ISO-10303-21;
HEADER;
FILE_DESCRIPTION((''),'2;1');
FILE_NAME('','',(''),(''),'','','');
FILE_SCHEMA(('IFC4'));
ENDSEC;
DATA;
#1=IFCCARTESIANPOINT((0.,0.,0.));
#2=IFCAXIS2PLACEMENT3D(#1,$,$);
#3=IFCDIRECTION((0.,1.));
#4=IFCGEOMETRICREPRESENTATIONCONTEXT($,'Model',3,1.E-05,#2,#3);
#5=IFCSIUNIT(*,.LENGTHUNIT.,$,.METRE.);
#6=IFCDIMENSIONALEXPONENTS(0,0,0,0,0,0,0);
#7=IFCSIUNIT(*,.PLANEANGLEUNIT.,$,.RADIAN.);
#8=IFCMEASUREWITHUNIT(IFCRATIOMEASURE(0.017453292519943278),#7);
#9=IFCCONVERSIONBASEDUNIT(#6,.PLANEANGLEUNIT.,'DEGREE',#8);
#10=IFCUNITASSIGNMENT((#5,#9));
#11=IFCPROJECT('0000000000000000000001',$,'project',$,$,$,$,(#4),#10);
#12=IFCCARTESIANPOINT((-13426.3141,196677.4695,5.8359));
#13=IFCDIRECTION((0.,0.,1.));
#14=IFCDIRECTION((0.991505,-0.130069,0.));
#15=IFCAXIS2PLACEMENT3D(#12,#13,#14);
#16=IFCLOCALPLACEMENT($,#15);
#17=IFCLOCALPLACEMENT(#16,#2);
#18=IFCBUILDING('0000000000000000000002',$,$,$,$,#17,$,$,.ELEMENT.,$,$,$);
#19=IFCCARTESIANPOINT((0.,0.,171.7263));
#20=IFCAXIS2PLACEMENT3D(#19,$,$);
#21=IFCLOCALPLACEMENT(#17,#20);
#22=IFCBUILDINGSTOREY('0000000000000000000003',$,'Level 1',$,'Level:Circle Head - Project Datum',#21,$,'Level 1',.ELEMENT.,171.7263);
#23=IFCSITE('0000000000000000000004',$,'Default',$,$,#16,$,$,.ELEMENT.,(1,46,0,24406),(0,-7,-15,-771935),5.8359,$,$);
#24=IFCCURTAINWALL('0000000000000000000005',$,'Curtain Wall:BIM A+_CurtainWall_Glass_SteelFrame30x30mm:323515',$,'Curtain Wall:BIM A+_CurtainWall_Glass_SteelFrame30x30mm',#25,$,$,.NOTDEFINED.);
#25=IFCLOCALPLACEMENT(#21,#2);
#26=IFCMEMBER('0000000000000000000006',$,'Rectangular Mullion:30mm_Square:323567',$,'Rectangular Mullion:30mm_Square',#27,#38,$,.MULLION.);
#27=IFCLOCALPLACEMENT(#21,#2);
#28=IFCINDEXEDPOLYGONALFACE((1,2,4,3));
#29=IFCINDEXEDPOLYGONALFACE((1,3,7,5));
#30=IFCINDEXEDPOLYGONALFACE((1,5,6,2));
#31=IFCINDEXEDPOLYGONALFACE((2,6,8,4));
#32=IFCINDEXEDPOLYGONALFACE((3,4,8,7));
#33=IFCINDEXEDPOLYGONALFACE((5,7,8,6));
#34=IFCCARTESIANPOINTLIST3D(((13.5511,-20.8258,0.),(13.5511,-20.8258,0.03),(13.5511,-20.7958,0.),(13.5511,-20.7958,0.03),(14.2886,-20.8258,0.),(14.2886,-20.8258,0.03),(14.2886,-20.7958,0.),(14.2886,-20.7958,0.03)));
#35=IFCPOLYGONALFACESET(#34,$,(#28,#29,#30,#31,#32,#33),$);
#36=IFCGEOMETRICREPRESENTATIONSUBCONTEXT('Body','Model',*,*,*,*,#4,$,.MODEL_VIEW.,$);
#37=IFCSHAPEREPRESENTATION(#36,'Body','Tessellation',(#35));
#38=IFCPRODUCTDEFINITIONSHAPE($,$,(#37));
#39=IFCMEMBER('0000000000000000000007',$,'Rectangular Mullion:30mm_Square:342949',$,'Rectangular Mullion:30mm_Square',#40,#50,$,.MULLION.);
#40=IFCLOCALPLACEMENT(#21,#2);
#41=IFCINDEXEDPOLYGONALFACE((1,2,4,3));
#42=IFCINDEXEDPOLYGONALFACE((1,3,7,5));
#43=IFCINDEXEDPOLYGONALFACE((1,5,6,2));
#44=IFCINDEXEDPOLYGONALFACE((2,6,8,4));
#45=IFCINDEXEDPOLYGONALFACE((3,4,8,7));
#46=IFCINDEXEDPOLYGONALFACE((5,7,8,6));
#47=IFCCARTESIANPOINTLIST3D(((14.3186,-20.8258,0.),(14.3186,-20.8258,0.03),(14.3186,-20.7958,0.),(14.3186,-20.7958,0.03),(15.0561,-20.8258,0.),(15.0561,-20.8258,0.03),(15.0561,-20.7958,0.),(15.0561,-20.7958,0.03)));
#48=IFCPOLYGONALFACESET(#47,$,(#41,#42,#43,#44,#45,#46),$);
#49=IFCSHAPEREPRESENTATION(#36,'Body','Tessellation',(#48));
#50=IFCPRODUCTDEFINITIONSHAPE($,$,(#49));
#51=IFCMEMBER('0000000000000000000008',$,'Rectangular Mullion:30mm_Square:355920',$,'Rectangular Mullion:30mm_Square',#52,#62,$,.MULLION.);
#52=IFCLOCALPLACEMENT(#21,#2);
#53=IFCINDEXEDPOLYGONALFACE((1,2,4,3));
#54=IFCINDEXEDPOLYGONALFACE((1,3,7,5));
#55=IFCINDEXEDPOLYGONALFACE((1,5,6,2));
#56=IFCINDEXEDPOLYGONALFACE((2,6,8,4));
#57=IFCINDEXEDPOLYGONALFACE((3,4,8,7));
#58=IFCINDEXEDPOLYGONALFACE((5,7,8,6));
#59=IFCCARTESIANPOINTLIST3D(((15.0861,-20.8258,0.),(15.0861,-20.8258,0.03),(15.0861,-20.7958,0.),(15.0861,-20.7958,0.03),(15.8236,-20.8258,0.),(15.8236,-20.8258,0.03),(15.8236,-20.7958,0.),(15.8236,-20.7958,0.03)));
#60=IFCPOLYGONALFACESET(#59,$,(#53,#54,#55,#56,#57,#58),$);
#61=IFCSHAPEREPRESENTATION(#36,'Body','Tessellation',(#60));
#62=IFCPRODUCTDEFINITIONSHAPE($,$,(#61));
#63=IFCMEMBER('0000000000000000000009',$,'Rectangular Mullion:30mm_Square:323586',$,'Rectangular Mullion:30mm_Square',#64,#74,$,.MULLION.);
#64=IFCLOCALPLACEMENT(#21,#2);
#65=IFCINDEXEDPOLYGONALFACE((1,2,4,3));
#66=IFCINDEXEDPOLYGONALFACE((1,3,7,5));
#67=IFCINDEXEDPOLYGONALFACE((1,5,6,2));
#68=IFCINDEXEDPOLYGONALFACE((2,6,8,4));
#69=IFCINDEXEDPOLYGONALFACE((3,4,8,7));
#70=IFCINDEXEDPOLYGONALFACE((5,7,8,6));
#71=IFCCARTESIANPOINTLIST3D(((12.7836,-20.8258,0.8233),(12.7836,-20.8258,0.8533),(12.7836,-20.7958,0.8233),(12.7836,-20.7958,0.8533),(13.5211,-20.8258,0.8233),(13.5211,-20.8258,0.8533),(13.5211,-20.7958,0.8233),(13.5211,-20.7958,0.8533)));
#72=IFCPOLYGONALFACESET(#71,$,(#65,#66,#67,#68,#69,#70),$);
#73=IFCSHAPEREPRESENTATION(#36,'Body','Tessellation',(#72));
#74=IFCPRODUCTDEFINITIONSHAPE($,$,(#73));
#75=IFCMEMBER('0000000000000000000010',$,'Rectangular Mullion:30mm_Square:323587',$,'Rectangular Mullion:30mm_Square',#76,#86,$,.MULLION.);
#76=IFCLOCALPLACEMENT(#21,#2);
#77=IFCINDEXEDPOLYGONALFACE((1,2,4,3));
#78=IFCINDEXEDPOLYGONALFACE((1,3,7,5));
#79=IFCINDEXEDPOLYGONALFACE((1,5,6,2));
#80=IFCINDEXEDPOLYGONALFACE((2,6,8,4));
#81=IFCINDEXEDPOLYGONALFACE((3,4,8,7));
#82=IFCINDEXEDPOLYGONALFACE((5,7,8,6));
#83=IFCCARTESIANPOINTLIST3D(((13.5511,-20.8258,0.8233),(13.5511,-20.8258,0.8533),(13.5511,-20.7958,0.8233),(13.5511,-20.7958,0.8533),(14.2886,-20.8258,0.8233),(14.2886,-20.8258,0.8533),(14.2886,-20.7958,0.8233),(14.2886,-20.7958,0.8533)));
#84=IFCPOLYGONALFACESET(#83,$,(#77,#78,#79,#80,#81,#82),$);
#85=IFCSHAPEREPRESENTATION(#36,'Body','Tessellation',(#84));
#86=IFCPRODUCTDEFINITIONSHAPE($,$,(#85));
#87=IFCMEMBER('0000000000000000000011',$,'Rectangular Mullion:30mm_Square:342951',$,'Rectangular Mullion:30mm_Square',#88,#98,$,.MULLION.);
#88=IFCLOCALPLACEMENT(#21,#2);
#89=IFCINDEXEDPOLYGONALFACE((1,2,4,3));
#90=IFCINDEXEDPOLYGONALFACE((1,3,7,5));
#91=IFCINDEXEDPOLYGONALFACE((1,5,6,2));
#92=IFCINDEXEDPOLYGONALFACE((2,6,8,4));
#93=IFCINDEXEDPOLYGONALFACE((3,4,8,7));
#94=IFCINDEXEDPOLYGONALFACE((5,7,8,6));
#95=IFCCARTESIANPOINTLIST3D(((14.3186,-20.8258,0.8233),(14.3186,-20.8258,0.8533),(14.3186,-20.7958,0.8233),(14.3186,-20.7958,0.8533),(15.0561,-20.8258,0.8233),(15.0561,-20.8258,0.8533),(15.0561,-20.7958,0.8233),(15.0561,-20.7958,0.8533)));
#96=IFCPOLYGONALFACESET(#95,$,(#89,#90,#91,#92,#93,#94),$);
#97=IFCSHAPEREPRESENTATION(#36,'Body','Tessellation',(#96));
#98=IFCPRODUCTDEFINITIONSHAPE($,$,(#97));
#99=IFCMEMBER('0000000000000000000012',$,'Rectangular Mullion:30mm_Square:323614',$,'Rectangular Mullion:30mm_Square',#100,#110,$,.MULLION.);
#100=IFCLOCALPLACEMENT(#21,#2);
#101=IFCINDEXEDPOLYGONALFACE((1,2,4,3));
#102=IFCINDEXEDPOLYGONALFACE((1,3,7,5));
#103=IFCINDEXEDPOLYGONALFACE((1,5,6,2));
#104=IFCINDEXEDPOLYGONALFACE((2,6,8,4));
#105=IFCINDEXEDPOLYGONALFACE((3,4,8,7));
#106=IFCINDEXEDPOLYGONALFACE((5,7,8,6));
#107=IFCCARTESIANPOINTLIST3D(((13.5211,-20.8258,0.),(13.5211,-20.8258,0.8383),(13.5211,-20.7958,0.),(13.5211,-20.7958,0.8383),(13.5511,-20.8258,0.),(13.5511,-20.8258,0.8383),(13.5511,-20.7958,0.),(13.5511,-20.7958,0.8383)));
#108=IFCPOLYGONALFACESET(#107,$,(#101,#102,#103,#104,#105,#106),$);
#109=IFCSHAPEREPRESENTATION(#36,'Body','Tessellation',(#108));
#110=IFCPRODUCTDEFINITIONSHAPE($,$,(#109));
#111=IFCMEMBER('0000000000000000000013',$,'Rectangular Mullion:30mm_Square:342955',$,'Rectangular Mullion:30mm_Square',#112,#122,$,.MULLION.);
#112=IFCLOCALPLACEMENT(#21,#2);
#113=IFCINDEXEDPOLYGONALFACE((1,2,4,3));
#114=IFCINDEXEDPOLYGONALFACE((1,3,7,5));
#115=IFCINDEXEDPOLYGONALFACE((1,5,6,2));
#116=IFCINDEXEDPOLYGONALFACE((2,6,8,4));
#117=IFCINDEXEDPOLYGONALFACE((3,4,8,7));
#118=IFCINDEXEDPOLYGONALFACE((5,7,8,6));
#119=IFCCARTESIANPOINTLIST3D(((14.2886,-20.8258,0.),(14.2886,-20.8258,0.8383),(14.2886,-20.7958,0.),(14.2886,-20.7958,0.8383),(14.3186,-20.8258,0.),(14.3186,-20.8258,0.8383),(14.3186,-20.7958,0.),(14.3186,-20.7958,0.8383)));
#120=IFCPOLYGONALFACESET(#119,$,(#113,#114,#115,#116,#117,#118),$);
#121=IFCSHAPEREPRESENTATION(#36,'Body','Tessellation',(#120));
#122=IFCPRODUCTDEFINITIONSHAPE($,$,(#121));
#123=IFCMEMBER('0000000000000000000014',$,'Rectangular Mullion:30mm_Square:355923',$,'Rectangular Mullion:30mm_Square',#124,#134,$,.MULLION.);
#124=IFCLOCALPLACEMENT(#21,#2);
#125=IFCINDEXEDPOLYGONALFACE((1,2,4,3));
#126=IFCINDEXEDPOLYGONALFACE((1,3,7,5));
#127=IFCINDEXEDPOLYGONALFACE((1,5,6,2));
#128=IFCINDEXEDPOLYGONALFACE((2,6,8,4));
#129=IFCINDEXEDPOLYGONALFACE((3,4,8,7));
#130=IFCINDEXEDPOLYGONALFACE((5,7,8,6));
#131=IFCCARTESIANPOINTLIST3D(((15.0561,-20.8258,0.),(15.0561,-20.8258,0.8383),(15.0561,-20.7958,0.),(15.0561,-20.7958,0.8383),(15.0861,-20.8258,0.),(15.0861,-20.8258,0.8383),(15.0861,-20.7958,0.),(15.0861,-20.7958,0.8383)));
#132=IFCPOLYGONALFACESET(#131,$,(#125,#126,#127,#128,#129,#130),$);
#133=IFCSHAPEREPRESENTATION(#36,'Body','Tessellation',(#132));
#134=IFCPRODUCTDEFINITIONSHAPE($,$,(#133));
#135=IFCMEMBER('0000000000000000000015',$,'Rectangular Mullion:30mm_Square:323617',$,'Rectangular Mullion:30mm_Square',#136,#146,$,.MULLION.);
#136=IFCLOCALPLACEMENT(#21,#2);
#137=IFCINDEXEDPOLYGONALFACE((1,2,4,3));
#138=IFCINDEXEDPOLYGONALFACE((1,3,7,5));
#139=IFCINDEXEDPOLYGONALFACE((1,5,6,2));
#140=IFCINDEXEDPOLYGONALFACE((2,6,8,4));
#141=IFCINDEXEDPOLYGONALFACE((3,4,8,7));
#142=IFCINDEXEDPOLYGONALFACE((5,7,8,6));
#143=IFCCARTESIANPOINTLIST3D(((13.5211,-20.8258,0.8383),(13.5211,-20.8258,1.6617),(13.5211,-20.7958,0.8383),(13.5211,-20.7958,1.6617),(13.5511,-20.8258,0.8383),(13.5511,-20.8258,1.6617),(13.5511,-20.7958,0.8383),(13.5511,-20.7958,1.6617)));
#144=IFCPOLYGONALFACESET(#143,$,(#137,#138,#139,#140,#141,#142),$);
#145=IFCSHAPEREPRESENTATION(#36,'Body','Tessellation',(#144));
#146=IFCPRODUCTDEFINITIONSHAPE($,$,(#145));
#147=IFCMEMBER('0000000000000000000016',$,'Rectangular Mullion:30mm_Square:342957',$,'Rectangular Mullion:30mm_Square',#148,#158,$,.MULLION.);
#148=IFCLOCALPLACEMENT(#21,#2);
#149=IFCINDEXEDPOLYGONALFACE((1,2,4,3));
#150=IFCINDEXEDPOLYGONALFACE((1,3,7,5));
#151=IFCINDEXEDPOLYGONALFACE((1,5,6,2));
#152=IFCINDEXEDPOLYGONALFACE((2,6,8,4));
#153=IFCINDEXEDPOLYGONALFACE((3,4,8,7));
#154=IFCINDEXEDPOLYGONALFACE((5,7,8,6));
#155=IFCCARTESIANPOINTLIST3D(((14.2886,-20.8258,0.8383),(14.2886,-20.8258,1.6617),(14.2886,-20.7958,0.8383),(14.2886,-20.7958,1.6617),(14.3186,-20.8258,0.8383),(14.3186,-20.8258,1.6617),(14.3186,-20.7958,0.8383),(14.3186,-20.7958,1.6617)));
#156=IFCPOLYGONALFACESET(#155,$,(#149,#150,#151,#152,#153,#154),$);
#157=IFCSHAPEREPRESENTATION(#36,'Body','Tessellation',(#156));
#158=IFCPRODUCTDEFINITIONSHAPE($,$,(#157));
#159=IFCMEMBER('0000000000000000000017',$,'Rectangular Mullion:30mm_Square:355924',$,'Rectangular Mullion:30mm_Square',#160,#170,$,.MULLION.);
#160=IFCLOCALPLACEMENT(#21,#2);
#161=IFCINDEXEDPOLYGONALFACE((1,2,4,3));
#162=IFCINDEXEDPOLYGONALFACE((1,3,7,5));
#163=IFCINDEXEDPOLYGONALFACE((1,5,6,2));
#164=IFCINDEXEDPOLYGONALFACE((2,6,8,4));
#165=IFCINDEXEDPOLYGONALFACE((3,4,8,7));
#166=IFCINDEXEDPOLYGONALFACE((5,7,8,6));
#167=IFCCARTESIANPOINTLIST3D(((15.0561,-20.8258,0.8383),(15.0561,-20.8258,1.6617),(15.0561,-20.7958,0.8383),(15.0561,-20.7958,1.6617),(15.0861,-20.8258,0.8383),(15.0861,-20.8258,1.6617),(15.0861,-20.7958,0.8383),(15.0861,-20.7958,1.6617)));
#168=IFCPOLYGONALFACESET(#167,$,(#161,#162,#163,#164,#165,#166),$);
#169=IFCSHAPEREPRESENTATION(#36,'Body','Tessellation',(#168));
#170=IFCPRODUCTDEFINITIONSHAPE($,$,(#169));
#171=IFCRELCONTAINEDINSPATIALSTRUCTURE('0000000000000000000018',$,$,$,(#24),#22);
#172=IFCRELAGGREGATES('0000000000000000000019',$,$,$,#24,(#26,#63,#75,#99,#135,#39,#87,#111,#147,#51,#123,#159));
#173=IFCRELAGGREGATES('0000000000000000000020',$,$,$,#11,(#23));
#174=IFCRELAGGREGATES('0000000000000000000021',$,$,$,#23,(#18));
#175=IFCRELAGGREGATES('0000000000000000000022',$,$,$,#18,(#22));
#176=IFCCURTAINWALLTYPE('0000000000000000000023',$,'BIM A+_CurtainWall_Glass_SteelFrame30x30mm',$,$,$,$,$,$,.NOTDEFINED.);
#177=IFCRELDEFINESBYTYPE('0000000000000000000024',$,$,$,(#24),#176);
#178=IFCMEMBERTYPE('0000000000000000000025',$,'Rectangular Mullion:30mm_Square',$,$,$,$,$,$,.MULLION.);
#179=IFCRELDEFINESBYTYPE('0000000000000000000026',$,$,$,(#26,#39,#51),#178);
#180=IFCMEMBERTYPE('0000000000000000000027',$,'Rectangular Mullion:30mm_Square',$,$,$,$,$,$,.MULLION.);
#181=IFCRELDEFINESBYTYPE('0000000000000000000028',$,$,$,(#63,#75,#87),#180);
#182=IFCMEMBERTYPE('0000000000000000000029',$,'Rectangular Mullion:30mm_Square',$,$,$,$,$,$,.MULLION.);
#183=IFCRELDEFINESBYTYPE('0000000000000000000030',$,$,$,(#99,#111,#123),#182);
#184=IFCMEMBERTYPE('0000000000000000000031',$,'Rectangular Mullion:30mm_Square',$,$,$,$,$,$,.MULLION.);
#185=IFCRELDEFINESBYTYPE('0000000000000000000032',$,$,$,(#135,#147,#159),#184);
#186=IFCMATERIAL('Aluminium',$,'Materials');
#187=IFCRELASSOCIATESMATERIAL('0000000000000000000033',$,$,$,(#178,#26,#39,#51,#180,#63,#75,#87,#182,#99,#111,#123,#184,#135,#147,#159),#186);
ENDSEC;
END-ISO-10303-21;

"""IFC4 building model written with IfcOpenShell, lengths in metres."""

from ifc_helpers import new_model, entity, si_unit, converted_unit, direction, frame, origin, place, context, subcontext, project, spatial, indexed_curve, outline, extrude, source, transform, mapped, material, type_object, type_shapes, element, aggregate, save


model = new_model("IFC4")

# Units and contexts
model_context = context("Model", 3, precision=1e-05, world=origin(), true_north=direction((0.0, 1.0)))
body_context = subcontext(model_context, "Body", "Model", "MODEL_VIEW")
ifc_project = project(units=[si_unit("LENGTHUNIT", "METRE"), converted_unit("PLANEANGLEUNIT", "DEGREE", entity("IfcRatioMeasure", 0.017453292519943278), si_unit("PLANEANGLEUNIT", "RADIAN"), dimensions=[0, 0, 0, 0, 0, 0, 0])], contexts=[model_context])

# Site, building, storey
site_placement = place(None, frame((-13426.3141, 196677.4695, 5.8359), z_axis=(0.0, 0.0, 1.0), x_axis=(0.991505, -0.130069, 0.0)))
site = spatial("IfcSite", under=ifc_project, at=site_placement, Name="Default", CompositionType="ELEMENT", RefLatitude=(1, 46, 0, 24406), RefLongitude=(0, -7, -15, -771935), RefElevation=5.8359)
building_placement = place(site_placement, origin())
building = spatial("IfcBuilding", under=site, at=building_placement, CompositionType="ELEMENT")
storey_placement = place(building_placement, frame((0.0, 0.0, 171.7263)))
storey = spatial("IfcBuildingStorey", under=building, at=storey_placement, Name="Level 1", ObjectType="Level:Circle Head - Project Datum", LongName="Level 1", CompositionType="ELEMENT", Elevation=171.7263)

# Curtain wall, members
curtain_wall_type_1 = type_object("IfcCurtainWallType", Name="BIM A+_CurtainWall_Glass_SteelFrame30x30mm", PredefinedType="NOTDEFINED")
curtain_wall_1_placement = place(storey_placement, frame((0.0, 0.0, -171.7263)))
curtain_wall_1 = element("IfcCurtainWall", 1, at=curtain_wall_1_placement, inside=storey, type_object=curtain_wall_type_1, Name="Curtain Wall:BIM A+_CurtainWall_Glass_SteelFrame30x30mm:323515", ObjectType="Curtain Wall:BIM A+_CurtainWall_Glass_SteelFrame30x30mm", PredefinedType="NOTDEFINED")
ifc_material_1 = material(Name="Aluminium", Category="Materials")
member_type_1 = type_object("IfcMemberType", Name="Rectangular Mullion:30mm_Square", PredefinedType="MULLION", material=ifc_material_1)
shared_shape_1 = source(origin(), body_context, "Body", "SweptSolid", [
    extrude(outline(indexed_curve([(-0.015, -0.015), (0.015, -0.015), (0.015, 0.015), (-0.015, 0.015), (-0.015, -0.015)], self_intersect=False)), frame((-0.015, 0.0, -0.7375), z_axis=(0.0, 0.0, 1.0), x_axis=(0.0, -1.0, 0.0)), (0.0, 0.0, 1.0), 0.7375),
])
type_shapes(member_type_1, [shared_shape_1])
member_1_placement = place(curtain_wall_1_placement, frame((13.5511, -20.8108, 171.7263), z_axis=(-1.0, 0.0, 0.0), x_axis=(0.0, 0.0, -1.0)))
member_1 = element("IfcMember", 2, at=member_1_placement, type_object=member_type_1, material=ifc_material_1, Name="Rectangular Mullion:30mm_Square:323567", ObjectType="Rectangular Mullion:30mm_Square", PredefinedType="MULLION", context=body_context, shape_type="MappedRepresentation", body=[
    mapped(shared_shape_1, transform((0.0, 0.0, 0.0), scale=1.0)),
])
member_2_placement = place(curtain_wall_1_placement, frame((14.3186, -20.8108, 171.7263), z_axis=(-1.0, 0.0, 0.0), x_axis=(0.0, 0.0, -1.0)))
member_2 = element("IfcMember", 3, at=member_2_placement, type_object=member_type_1, material=ifc_material_1, Name="Rectangular Mullion:30mm_Square:342949", ObjectType="Rectangular Mullion:30mm_Square", PredefinedType="MULLION", context=body_context, shape_type="MappedRepresentation", body=[
    mapped(shared_shape_1, transform((0.0, 0.0, 0.0), scale=1.0)),
])
member_3_placement = place(curtain_wall_1_placement, frame((15.0861, -20.8108, 171.7263), z_axis=(-1.0, 0.0, 0.0), x_axis=(0.0, 0.0, -1.0)))
member_3 = element("IfcMember", 4, at=member_3_placement, type_object=member_type_1, material=ifc_material_1, Name="Rectangular Mullion:30mm_Square:355920", ObjectType="Rectangular Mullion:30mm_Square", PredefinedType="MULLION", context=body_context, shape_type="MappedRepresentation", body=[
    mapped(shared_shape_1, transform((0.0, 0.0, 0.0), scale=1.0)),
])
member_type_2 = type_object("IfcMemberType", Name="Rectangular Mullion:30mm_Square", PredefinedType="MULLION", material=ifc_material_1)
shared_shape_2 = source(origin(), body_context, "Body", "SweptSolid", [
    extrude(outline(indexed_curve([(-0.015, -0.015), (0.015, -0.015), (0.015, 0.015), (-0.015, 0.015), (-0.015, -0.015)], self_intersect=False)), frame((0.0, 0.0, -0.7375), z_axis=(0.0, 0.0, 1.0), x_axis=(0.0, -1.0, 0.0)), (0.0, 0.0, 1.0), 0.7375),
])
type_shapes(member_type_2, [shared_shape_2])
member_4_placement = place(curtain_wall_1_placement, frame((13.5211, -20.8108, 172.5646), z_axis=(1.0, 0.0, 0.0), x_axis=(0.0, 0.0, 1.0)))
member_4 = element("IfcMember", 5, at=member_4_placement, type_object=member_type_2, material=ifc_material_1, Name="Rectangular Mullion:30mm_Square:323586", ObjectType="Rectangular Mullion:30mm_Square", PredefinedType="MULLION", context=body_context, shape_type="MappedRepresentation", body=[
    mapped(shared_shape_2, transform((0.0, 0.0, 0.0), scale=1.0)),
])
member_5_placement = place(curtain_wall_1_placement, frame((14.2886, -20.8108, 172.5646), z_axis=(1.0, 0.0, 0.0), x_axis=(0.0, 0.0, 1.0)))
member_5 = element("IfcMember", 6, at=member_5_placement, type_object=member_type_2, material=ifc_material_1, Name="Rectangular Mullion:30mm_Square:323587", ObjectType="Rectangular Mullion:30mm_Square", PredefinedType="MULLION", context=body_context, shape_type="MappedRepresentation", body=[
    mapped(shared_shape_2, transform((0.0, 0.0, 0.0), scale=1.0)),
])
member_6_placement = place(curtain_wall_1_placement, frame((15.0561, -20.8108, 172.5646), z_axis=(1.0, 0.0, 0.0), x_axis=(0.0, 0.0, 1.0)))
member_6 = element("IfcMember", 7, at=member_6_placement, type_object=member_type_2, material=ifc_material_1, Name="Rectangular Mullion:30mm_Square:342951", ObjectType="Rectangular Mullion:30mm_Square", PredefinedType="MULLION", context=body_context, shape_type="MappedRepresentation", body=[
    mapped(shared_shape_2, transform((0.0, 0.0, 0.0), scale=1.0)),
])
member_type_3 = type_object("IfcMemberType", Name="Rectangular Mullion:30mm_Square", PredefinedType="MULLION", material=ifc_material_1)
shared_shape_3 = source(origin(), body_context, "Body", "SweptSolid", [
    extrude(outline(indexed_curve([(-0.015, -0.015), (0.015, -0.015), (0.015, 0.015), (-0.015, 0.015), (-0.015, -0.015)], self_intersect=False)), frame((0.0, 0.0, -0.8383), z_axis=(0.0, 0.0, 1.0), x_axis=(0.0, -1.0, 0.0)), (0.0, 0.0, 1.0), 0.8383),
])
type_shapes(member_type_3, [shared_shape_3])
member_7_placement = place(curtain_wall_1_placement, frame((13.5361, -20.8108, 171.7263), z_axis=(0.0, 0.0, -1.0), x_axis=(1.0, 0.0, 0.0)))
member_7 = element("IfcMember", 8, at=member_7_placement, type_object=member_type_3, material=ifc_material_1, Name="Rectangular Mullion:30mm_Square:323614", ObjectType="Rectangular Mullion:30mm_Square", PredefinedType="MULLION", context=body_context, shape_type="MappedRepresentation", body=[
    mapped(shared_shape_3, transform((0.0, 0.0, 0.0), scale=1.0)),
])
member_8_placement = place(curtain_wall_1_placement, frame((14.3036, -20.8108, 171.7263), z_axis=(0.0, 0.0, -1.0), x_axis=(1.0, 0.0, 0.0)))
member_8 = element("IfcMember", 9, at=member_8_placement, type_object=member_type_3, material=ifc_material_1, Name="Rectangular Mullion:30mm_Square:342955", ObjectType="Rectangular Mullion:30mm_Square", PredefinedType="MULLION", context=body_context, shape_type="MappedRepresentation", body=[
    mapped(shared_shape_3, transform((0.0, 0.0, 0.0), scale=1.0)),
])
member_9_placement = place(curtain_wall_1_placement, frame((15.0711, -20.8108, 171.7263), z_axis=(0.0, 0.0, -1.0), x_axis=(1.0, 0.0, 0.0)))
member_9 = element("IfcMember", 10, at=member_9_placement, type_object=member_type_3, material=ifc_material_1, Name="Rectangular Mullion:30mm_Square:355923", ObjectType="Rectangular Mullion:30mm_Square", PredefinedType="MULLION", context=body_context, shape_type="MappedRepresentation", body=[
    mapped(shared_shape_3, transform((0.0, 0.0, 0.0), scale=1.0)),
])
member_type_4 = type_object("IfcMemberType", Name="Rectangular Mullion:30mm_Square", PredefinedType="MULLION", material=ifc_material_1)
shared_shape_4 = source(origin(), body_context, "Body", "SweptSolid", [
    extrude(outline(indexed_curve([(-0.015, -0.015), (0.015, -0.015), (0.015, 0.015), (-0.015, 0.015), (-0.015, -0.015)], self_intersect=False)), frame((0.0, 0.0, -0.8233), z_axis=(0.0, 0.0, 1.0), x_axis=(0.0, -1.0, 0.0)), (0.0, 0.0, 1.0), 0.8233),
])
type_shapes(member_type_4, [shared_shape_4])
member_10_placement = place(curtain_wall_1_placement, frame((13.5361, -20.8108, 172.5646), z_axis=(0.0, 0.0, -1.0), x_axis=(1.0, 0.0, 0.0)))
member_10 = element("IfcMember", 11, at=member_10_placement, type_object=member_type_4, material=ifc_material_1, Name="Rectangular Mullion:30mm_Square:323617", ObjectType="Rectangular Mullion:30mm_Square", PredefinedType="MULLION", context=body_context, shape_type="MappedRepresentation", body=[
    mapped(shared_shape_4, transform((0.0, 0.0, 0.0), scale=1.0)),
])
member_11_placement = place(curtain_wall_1_placement, frame((14.3036, -20.8108, 172.5646), z_axis=(0.0, 0.0, -1.0), x_axis=(1.0, 0.0, 0.0)))
member_11 = element("IfcMember", 12, at=member_11_placement, type_object=member_type_4, material=ifc_material_1, Name="Rectangular Mullion:30mm_Square:342957", ObjectType="Rectangular Mullion:30mm_Square", PredefinedType="MULLION", context=body_context, shape_type="MappedRepresentation", body=[
    mapped(shared_shape_4, transform((0.0, 0.0, 0.0), scale=1.0)),
])
member_12_placement = place(curtain_wall_1_placement, frame((15.0711, -20.8108, 172.5646), z_axis=(0.0, 0.0, -1.0), x_axis=(1.0, 0.0, 0.0)))
member_12 = element("IfcMember", 13, at=member_12_placement, type_object=member_type_4, material=ifc_material_1, Name="Rectangular Mullion:30mm_Square:355924", ObjectType="Rectangular Mullion:30mm_Square", PredefinedType="MULLION", context=body_context, shape_type="MappedRepresentation", body=[
    mapped(shared_shape_4, transform((0.0, 0.0, 0.0), scale=1.0)),
])
aggregate(curtain_wall_1, [member_1, member_4, member_5, member_7, member_10, member_2, member_6, member_8, member_11, member_3, member_9, member_12])

save(model, "model.ifc")
